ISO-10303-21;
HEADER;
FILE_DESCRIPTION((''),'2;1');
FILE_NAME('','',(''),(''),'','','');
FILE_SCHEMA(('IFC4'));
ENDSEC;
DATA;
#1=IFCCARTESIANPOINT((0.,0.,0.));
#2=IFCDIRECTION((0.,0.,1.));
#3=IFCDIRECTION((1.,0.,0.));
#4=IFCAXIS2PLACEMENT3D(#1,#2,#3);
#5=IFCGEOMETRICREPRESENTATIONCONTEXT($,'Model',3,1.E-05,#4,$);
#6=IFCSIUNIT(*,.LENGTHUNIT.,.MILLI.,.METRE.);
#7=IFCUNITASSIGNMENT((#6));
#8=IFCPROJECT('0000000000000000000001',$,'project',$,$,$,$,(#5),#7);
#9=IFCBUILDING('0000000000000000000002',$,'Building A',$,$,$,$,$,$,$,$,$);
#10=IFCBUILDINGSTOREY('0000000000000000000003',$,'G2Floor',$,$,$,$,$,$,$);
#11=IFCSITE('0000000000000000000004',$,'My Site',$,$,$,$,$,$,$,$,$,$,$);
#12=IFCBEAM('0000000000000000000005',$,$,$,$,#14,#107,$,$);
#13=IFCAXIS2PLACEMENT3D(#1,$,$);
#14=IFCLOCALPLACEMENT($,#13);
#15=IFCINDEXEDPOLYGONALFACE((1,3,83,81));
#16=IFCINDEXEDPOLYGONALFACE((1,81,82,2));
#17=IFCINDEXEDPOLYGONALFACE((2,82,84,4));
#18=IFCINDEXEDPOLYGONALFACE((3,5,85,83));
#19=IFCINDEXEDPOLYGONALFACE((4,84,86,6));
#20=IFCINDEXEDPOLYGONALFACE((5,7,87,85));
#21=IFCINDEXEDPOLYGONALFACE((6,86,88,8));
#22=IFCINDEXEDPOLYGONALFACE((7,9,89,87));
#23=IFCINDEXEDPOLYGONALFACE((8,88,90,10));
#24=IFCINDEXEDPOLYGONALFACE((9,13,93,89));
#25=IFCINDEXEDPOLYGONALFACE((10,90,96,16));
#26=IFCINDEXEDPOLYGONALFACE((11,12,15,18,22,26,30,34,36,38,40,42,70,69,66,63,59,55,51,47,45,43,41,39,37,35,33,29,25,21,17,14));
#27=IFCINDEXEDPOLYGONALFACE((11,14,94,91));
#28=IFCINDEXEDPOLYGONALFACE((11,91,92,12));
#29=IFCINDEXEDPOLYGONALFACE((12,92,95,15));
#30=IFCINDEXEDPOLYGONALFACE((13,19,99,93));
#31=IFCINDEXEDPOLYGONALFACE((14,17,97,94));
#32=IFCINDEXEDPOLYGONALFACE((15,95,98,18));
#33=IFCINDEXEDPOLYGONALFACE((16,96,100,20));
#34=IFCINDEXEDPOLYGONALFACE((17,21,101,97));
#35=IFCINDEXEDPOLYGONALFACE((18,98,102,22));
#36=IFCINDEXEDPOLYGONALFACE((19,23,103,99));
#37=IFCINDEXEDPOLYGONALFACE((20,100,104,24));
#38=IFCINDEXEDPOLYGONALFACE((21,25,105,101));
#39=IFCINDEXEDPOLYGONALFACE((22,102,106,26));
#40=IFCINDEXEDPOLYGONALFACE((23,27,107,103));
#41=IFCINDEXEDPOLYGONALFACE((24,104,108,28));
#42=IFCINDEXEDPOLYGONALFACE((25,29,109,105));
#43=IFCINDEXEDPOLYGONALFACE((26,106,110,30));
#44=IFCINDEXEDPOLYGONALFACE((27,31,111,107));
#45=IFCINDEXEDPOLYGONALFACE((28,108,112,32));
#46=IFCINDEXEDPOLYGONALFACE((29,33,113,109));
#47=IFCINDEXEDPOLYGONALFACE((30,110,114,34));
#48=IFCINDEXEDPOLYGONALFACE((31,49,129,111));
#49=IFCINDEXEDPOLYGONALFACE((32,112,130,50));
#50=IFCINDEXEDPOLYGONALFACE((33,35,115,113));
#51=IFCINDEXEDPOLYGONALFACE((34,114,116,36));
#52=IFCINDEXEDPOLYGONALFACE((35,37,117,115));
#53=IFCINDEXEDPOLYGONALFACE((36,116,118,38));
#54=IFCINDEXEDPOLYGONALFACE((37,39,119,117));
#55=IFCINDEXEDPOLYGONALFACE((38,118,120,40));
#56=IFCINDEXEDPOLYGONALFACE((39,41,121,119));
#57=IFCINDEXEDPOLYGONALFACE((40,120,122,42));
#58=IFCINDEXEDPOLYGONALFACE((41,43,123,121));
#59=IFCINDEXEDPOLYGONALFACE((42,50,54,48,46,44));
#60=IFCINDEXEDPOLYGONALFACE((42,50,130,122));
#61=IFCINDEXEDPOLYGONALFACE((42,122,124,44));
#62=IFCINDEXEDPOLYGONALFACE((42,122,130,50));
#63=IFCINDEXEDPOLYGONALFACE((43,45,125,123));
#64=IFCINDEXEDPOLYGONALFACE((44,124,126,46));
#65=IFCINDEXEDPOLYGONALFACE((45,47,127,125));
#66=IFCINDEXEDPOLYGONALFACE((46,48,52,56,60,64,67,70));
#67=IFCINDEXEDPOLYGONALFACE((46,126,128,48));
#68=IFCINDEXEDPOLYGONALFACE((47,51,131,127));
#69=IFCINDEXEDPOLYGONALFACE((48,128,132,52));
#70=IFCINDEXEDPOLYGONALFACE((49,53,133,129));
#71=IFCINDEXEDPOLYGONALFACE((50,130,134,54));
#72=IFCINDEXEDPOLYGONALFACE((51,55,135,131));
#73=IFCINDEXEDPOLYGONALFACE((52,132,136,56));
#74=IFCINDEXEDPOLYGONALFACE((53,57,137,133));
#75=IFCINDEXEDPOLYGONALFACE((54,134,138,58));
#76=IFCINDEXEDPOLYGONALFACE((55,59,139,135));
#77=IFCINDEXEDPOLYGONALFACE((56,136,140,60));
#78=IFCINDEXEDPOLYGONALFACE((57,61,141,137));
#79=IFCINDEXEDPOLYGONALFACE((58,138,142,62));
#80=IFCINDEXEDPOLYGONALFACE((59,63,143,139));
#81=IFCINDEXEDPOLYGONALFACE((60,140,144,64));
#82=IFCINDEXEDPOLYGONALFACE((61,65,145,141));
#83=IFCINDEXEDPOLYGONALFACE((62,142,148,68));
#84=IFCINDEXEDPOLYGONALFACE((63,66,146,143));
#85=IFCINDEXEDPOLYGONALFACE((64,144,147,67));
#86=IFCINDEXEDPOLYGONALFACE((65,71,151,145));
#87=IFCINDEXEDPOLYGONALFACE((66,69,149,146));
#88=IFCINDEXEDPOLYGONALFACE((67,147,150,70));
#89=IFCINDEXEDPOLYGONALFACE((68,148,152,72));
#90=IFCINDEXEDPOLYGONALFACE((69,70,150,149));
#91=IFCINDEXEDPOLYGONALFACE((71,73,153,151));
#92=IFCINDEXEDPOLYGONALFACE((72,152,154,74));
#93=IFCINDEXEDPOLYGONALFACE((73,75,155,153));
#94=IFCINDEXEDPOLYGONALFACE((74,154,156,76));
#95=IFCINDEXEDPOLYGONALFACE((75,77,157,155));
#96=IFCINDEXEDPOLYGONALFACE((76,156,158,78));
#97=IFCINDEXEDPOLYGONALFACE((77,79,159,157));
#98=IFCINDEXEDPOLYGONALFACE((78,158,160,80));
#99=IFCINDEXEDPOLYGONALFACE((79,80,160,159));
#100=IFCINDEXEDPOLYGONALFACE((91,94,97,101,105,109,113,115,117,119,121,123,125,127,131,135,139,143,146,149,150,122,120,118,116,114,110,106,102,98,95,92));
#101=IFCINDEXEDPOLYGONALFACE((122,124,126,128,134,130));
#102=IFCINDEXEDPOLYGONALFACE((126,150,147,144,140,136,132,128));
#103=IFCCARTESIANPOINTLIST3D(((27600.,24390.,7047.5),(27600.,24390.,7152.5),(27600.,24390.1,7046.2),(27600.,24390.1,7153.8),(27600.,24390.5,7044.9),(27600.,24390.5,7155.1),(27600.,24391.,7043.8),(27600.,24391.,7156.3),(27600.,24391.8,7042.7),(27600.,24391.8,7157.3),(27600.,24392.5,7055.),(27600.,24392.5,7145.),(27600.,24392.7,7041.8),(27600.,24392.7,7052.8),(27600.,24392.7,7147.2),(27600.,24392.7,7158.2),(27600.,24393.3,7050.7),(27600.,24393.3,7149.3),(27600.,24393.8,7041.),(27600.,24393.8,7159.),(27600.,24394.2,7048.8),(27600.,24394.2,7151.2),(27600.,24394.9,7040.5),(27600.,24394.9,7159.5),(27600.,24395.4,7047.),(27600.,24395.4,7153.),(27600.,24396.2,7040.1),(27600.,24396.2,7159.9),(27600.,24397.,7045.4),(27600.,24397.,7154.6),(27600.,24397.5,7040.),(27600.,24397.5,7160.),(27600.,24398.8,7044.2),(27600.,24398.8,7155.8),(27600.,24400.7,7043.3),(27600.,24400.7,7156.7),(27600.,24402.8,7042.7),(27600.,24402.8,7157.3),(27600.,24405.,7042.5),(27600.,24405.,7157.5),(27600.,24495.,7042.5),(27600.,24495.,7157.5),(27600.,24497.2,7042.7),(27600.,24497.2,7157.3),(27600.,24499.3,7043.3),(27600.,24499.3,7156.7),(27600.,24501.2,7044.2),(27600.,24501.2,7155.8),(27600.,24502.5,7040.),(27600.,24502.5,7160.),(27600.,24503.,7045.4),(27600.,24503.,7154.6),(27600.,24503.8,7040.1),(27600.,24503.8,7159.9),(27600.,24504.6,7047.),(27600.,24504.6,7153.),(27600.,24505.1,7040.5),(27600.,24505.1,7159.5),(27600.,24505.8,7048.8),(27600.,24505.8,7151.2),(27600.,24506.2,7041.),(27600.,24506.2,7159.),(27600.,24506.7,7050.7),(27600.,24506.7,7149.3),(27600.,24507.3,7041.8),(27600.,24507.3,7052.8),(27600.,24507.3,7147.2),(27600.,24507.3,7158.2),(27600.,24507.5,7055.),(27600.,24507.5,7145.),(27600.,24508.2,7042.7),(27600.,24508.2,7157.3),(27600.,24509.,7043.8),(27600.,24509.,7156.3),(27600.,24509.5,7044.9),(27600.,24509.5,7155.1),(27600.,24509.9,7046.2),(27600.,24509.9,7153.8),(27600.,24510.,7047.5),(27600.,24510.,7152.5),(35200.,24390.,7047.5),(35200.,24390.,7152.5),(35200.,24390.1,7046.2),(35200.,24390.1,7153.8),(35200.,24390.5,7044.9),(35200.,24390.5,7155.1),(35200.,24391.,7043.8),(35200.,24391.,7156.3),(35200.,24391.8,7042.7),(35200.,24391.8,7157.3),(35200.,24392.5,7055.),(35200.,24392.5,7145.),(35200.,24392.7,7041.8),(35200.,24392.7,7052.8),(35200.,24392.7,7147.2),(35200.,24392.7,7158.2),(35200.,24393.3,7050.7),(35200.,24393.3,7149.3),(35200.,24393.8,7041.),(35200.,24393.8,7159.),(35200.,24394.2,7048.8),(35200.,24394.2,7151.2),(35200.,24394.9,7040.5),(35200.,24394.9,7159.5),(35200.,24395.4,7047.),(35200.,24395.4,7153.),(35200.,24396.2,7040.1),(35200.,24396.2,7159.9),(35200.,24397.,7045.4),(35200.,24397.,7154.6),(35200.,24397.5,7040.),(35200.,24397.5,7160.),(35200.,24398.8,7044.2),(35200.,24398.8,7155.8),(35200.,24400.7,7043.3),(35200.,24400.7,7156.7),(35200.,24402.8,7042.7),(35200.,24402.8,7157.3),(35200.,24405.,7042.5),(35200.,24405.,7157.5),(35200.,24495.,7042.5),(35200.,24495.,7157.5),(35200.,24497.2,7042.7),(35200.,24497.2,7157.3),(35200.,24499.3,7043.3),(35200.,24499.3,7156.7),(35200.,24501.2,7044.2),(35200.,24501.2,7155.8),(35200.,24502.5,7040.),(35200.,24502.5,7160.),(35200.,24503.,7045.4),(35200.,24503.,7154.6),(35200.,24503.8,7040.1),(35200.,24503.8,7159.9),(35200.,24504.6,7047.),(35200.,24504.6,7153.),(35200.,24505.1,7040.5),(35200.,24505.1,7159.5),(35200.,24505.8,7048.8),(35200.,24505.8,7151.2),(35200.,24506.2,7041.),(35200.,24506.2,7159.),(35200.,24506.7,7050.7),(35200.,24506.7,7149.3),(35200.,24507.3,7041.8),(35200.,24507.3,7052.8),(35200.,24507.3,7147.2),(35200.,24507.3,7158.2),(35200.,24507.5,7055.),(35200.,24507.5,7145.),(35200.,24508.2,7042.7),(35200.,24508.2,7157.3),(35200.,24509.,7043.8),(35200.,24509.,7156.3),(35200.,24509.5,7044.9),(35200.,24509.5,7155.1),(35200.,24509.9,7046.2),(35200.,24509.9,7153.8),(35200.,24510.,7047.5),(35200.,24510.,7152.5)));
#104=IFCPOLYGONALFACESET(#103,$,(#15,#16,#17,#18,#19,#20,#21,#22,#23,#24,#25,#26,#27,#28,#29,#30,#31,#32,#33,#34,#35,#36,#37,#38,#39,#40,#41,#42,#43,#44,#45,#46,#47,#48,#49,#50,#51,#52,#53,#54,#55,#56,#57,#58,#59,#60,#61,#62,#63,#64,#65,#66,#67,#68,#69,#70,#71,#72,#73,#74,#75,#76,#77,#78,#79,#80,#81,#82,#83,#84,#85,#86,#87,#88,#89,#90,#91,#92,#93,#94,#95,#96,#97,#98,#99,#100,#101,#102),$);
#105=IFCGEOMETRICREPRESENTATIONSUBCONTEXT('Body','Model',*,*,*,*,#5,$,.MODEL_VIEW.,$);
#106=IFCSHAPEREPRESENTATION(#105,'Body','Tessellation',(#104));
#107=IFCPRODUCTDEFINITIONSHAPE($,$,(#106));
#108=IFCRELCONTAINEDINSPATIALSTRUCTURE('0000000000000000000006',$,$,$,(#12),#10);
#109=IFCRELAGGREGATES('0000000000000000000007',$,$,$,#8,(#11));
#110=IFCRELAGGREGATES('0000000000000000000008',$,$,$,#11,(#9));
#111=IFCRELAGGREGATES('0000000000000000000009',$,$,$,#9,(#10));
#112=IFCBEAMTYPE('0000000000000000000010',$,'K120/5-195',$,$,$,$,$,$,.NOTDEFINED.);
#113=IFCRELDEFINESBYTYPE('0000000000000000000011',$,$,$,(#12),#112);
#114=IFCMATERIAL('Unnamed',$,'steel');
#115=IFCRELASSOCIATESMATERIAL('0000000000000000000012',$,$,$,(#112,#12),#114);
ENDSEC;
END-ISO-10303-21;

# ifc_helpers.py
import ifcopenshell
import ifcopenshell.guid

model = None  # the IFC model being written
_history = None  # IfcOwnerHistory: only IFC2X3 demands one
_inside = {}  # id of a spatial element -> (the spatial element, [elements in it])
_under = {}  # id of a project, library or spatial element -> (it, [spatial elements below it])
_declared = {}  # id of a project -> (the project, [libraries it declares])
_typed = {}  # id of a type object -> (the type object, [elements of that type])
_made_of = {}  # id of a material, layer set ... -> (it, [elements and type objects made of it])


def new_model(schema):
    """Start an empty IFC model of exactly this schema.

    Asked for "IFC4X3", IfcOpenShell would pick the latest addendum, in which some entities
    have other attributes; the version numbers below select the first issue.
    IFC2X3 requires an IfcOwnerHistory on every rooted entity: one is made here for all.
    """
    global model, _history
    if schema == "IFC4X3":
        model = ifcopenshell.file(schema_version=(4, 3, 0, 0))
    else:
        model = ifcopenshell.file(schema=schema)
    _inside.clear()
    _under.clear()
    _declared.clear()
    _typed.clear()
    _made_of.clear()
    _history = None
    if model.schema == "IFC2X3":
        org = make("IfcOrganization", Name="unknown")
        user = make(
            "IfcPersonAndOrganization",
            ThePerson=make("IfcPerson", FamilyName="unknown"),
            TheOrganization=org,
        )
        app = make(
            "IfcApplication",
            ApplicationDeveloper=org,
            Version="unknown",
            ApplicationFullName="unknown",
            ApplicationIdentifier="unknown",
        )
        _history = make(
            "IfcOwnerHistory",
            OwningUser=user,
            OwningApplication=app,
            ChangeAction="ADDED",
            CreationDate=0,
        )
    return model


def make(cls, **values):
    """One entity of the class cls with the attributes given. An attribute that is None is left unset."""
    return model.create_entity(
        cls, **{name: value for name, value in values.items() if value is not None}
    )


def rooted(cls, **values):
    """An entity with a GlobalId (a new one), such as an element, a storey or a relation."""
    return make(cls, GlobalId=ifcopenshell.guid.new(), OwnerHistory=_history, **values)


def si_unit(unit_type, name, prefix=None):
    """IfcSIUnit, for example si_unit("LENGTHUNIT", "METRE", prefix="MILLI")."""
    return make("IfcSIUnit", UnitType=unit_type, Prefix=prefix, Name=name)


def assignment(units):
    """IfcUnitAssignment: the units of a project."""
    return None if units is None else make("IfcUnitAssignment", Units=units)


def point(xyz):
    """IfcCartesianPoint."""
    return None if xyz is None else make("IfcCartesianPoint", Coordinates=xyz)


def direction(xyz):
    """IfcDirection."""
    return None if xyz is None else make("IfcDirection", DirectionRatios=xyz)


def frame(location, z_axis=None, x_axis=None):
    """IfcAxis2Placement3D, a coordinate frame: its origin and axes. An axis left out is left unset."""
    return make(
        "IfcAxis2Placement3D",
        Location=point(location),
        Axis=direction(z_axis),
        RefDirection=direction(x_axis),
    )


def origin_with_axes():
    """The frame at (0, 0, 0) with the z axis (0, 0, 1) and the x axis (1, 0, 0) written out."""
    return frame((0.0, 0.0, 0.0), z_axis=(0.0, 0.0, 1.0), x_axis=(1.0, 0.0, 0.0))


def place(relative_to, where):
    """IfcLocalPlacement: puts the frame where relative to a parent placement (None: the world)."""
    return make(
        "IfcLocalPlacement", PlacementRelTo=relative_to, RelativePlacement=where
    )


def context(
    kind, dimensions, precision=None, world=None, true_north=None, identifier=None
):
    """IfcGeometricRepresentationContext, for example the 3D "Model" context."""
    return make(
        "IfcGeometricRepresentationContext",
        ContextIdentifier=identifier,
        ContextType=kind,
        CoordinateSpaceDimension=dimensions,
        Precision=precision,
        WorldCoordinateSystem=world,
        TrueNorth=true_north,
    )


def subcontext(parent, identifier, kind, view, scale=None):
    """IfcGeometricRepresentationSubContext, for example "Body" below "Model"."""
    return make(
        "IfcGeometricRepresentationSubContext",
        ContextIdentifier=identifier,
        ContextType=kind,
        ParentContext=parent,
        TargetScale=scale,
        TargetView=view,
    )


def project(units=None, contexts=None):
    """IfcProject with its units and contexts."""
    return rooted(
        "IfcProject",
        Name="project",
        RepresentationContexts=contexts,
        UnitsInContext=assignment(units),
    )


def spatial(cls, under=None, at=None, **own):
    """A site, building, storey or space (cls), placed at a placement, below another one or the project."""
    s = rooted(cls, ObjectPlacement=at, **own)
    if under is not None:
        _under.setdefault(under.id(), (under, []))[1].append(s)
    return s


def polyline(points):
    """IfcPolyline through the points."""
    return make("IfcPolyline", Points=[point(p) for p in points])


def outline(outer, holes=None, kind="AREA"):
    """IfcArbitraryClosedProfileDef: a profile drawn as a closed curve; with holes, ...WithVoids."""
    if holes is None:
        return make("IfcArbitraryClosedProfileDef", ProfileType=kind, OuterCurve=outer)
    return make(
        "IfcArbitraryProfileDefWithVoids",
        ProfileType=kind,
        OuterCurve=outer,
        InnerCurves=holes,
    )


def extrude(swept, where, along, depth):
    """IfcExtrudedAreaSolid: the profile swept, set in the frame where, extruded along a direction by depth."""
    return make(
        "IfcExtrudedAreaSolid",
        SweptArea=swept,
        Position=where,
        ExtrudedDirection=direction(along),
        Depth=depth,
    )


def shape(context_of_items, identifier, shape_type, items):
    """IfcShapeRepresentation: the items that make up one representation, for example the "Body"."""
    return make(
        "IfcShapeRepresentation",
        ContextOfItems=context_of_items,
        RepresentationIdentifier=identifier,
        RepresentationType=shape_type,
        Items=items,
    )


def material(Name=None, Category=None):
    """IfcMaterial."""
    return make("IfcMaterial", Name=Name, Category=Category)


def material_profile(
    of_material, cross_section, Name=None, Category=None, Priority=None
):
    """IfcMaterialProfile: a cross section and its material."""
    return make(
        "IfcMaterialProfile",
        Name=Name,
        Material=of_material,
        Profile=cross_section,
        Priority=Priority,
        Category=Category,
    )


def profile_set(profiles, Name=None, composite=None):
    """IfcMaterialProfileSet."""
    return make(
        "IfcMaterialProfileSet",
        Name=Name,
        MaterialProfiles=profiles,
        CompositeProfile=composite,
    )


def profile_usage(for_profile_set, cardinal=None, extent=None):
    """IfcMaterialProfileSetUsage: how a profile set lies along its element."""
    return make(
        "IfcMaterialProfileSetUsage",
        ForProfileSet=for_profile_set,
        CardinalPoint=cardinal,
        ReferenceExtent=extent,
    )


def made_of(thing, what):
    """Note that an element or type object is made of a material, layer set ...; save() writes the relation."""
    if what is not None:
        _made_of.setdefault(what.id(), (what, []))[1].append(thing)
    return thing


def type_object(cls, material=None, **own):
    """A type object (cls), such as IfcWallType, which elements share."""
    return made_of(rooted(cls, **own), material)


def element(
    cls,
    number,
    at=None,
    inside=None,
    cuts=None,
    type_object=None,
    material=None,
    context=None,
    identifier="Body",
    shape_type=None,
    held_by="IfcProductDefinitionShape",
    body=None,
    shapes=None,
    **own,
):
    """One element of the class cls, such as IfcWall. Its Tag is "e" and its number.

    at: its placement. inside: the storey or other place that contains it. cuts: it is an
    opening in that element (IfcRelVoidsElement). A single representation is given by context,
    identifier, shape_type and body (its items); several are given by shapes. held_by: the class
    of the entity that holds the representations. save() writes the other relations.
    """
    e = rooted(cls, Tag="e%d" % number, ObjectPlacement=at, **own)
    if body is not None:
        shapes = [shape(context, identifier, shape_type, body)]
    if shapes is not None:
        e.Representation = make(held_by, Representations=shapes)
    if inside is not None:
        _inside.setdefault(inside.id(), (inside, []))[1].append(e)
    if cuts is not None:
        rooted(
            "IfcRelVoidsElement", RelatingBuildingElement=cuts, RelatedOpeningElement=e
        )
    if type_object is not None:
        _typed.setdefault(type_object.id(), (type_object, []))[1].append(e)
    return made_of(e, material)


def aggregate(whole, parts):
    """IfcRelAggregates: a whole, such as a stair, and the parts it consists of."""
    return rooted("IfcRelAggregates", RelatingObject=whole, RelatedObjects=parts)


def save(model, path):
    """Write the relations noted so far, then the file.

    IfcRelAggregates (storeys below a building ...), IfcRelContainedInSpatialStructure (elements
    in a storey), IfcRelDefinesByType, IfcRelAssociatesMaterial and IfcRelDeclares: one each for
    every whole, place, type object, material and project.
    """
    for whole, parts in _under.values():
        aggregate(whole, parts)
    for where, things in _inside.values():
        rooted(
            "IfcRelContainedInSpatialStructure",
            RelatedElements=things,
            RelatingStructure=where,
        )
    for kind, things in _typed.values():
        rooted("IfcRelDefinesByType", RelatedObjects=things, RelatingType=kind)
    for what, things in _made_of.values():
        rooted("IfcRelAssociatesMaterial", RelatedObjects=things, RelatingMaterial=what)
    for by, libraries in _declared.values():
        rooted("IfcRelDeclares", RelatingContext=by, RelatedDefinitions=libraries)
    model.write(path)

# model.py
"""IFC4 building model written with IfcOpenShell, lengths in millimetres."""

from ifc_helpers import new_model, si_unit, frame, origin_with_axes, place, context, subcontext, project, spatial, polyline, outline, extrude, material, material_profile, profile_set, profile_usage, type_object, element, save


model = new_model("IFC4")

# Units and contexts
model_context = context("Model", 3, precision=1e-05, world=origin_with_axes())
body_context = subcontext(model_context, "Body", "Model", "MODEL_VIEW")
ifc_project = project(units=[si_unit("LENGTHUNIT", "METRE", prefix="MILLI")], contexts=[model_context])

# Site, building, storey
site = spatial("IfcSite", under=ifc_project, Name="My Site")
building = spatial("IfcBuilding", under=site, Name="Building A")
storey = spatial("IfcBuildingStorey", under=building, Name="G2Floor")

# Beam
ifc_material_1 = material(Name="Unnamed", Category="steel")
ifc_material_profile_1 = material_profile(ifc_material_1, outline(polyline([(-52.5, -60.0), (52.5, -60.0), (52.5, -60.0), (53.8, -59.9), (53.8, -59.9), (55.1, -59.5), (55.1, -59.5), (56.2, -59.0), (56.2, -59.0), (57.3, -58.2), (57.3, -58.2), (58.2, -57.3), (58.2, -57.3), (59.0, -56.2), (59.0, -56.2), (59.5, -55.1), (59.5, -55.1), (59.9, -53.8), (59.9, -53.8), (60.0, -52.5), (60.0, -52.5), (60.0, 52.5), (60.0, 52.5), (59.9, 53.8), (59.9, 53.8), (59.5, 55.1), (59.5, 55.1), (59.0, 56.2), (59.0, 56.2), (58.2, 57.3), (58.2, 57.3), (57.3, 58.2), (57.3, 58.2), (56.2, 59.0), (56.2, 59.0), (55.1, 59.5), (55.1, 59.5), (53.8, 59.9), (53.8, 59.9), (52.5, 60.0), (52.5, 60.0), (-52.5, 60.0), (-52.5, 60.0), (-53.8, 59.9), (-53.8, 59.9), (-55.1, 59.5), (-55.1, 59.5), (-56.2, 59.0), (-56.2, 59.0), (-57.3, 58.2), (-57.3, 58.2), (-58.2, 57.3), (-58.2, 57.3), (-59.0, 56.2), (-59.0, 56.2), (-59.5, 55.1), (-59.5, 55.1), (-59.9, 53.8), (-59.9, 53.8), (-60.0, 52.5), (-60.0, 52.5), (-60.0, -52.5), (-60.0, -52.5), (-59.9, -53.8), (-59.9, -53.8), (-59.5, -55.1), (-59.5, -55.1), (-59.0, -56.2), (-59.0, -56.2), (-58.2, -57.3), (-58.2, -57.3), (-57.3, -58.2), (-57.3, -58.2), (-56.2, -59.0), (-56.2, -59.0), (-55.1, -59.5), (-55.1, -59.5), (-53.8, -59.9), (-53.8, -59.9), (-52.5, -60.0), (-52.5, -60.0), (-45.0, -57.5), (-45.0, -57.5), (45.0, -57.5), (45.0, -57.5), (47.2, -57.3), (47.2, -57.3), (49.3, -56.7), (49.3, -56.7), (51.2, -55.8), (51.2, -55.8), (53.0, -54.6), (53.0, -54.6), (54.6, -53.0), (54.6, -53.0), (55.8, -51.2), (55.8, -51.2), (56.7, -49.3), (56.7, -49.3), (57.3, -47.2), (57.3, -47.2), (57.5, -45.0), (57.5, -45.0), (57.5, 45.0), (57.5, 45.0), (57.3, 47.2), (57.3, 47.2), (56.7, 49.3), (56.7, 49.3), (55.8, 51.2), (55.8, 51.2), (54.6, 53.0), (54.6, 53.0), (53.0, 54.6), (53.0, 54.6), (51.2, 55.8), (51.2, 55.8), (49.3, 56.7), (49.3, 56.7), (47.2, 57.3), (47.2, 57.3), (45.0, 57.5), (45.0, 57.5), (-45.0, 57.5), (-45.0, 57.5), (-47.2, 57.3), (-47.2, 57.3), (-49.3, 56.7), (-49.3, 56.7), (-51.2, 55.8), (-51.2, 55.8), (-53.0, 54.6), (-53.0, 54.6), (-54.6, 53.0), (-54.6, 53.0), (-55.8, 51.2), (-55.8, 51.2), (-56.7, 49.3), (-56.7, 49.3), (-57.3, 47.2), (-57.3, 47.2), (-57.5, 45.0), (-57.5, 45.0), (-57.5, -45.0), (-57.5, -45.0), (-57.3, -47.2), (-57.3, -47.2), (-56.7, -49.3), (-56.7, -49.3), (-55.8, -51.2), (-55.8, -51.2), (-54.6, -53.0), (-54.6, -53.0), (-53.0, -54.6), (-53.0, -54.6), (-51.2, -55.8), (-51.2, -55.8), (-49.3, -56.7), (-49.3, -56.7), (-47.2, -57.3), (-47.2, -57.3), (-45.0, -57.5), (-45.0, -57.5), (-52.5, -60.0)])))
ifc_profile_set_1 = profile_set([ifc_material_profile_1], Name="K120/5-195")
ifc_profile_usage_1 = profile_usage(ifc_profile_set_1)
beam_type_1 = type_object("IfcBeamType", Name="K120/5-195", PredefinedType="NOTDEFINED", material=ifc_profile_set_1)
beam_1_placement = place(None, frame((27600.0, 24450.0, 7100.0), z_axis=(1.0, 0.0, 0.0), x_axis=(0.0, -1.0, 0.0)))
element("IfcBeam", 1, at=beam_1_placement, inside=storey, type_object=beam_type_1, material=ifc_profile_usage_1, context=body_context, shape_type="SweptSolid", body=[
    extrude(outline(polyline([(-52.5, -60.0), (52.5, -60.0), (52.5, -60.0), (53.8, -59.9), (53.8, -59.9), (55.1, -59.5), (55.1, -59.5), (56.2, -59.0), (56.2, -59.0), (57.3, -58.2), (57.3, -58.2), (58.2, -57.3), (58.2, -57.3), (59.0, -56.2), (59.0, -56.2), (59.5, -55.1), (59.5, -55.1), (59.9, -53.8), (59.9, -53.8), (60.0, -52.5), (60.0, -52.5), (60.0, 52.5), (60.0, 52.5), (59.9, 53.8), (59.9, 53.8), (59.5, 55.1), (59.5, 55.1), (59.0, 56.2), (59.0, 56.2), (58.2, 57.3), (58.2, 57.3), (57.3, 58.2), (57.3, 58.2), (56.2, 59.0), (56.2, 59.0), (55.1, 59.5), (55.1, 59.5), (53.8, 59.9), (53.8, 59.9), (52.5, 60.0), (52.5, 60.0), (-52.5, 60.0), (-52.5, 60.0), (-53.8, 59.9), (-53.8, 59.9), (-55.1, 59.5), (-55.1, 59.5), (-56.2, 59.0), (-56.2, 59.0), (-57.3, 58.2), (-57.3, 58.2), (-58.2, 57.3), (-58.2, 57.3), (-59.0, 56.2), (-59.0, 56.2), (-59.5, 55.1), (-59.5, 55.1), (-59.9, 53.8), (-59.9, 53.8), (-60.0, 52.5), (-60.0, 52.5), (-60.0, -52.5), (-60.0, -52.5), (-59.9, -53.8), (-59.9, -53.8), (-59.5, -55.1), (-59.5, -55.1), (-59.0, -56.2), (-59.0, -56.2), (-58.2, -57.3), (-58.2, -57.3), (-57.3, -58.2), (-57.3, -58.2), (-56.2, -59.0), (-56.2, -59.0), (-55.1, -59.5), (-55.1, -59.5), (-53.8, -59.9), (-53.8, -59.9), (-52.5, -60.0), (-52.5, -60.0), (-45.0, -57.5), (-45.0, -57.5), (45.0, -57.5), (45.0, -57.5), (47.2, -57.3), (47.2, -57.3), (49.3, -56.7), (49.3, -56.7), (51.2, -55.8), (51.2, -55.8), (53.0, -54.6), (53.0, -54.6), (54.6, -53.0), (54.6, -53.0), (55.8, -51.2), (55.8, -51.2), (56.7, -49.3), (56.7, -49.3), (57.3, -47.2), (57.3, -47.2), (57.5, -45.0), (57.5, -45.0), (57.5, 45.0), (57.5, 45.0), (57.3, 47.2), (57.3, 47.2), (56.7, 49.3), (56.7, 49.3), (55.8, 51.2), (55.8, 51.2), (54.6, 53.0), (54.6, 53.0), (53.0, 54.6), (53.0, 54.6), (51.2, 55.8), (51.2, 55.8), (49.3, 56.7), (49.3, 56.7), (47.2, 57.3), (47.2, 57.3), (45.0, 57.5), (45.0, 57.5), (-45.0, 57.5), (-45.0, 57.5), (-47.2, 57.3), (-47.2, 57.3), (-49.3, 56.7), (-49.3, 56.7), (-51.2, 55.8), (-51.2, 55.8), (-53.0, 54.6), (-53.0, 54.6), (-54.6, 53.0), (-54.6, 53.0), (-55.8, 51.2), (-55.8, 51.2), (-56.7, 49.3), (-56.7, 49.3), (-57.3, 47.2), (-57.3, 47.2), (-57.5, 45.0), (-57.5, 45.0), (-57.5, -45.0), (-57.5, -45.0), (-57.3, -47.2), (-57.3, -47.2), (-56.7, -49.3), (-56.7, -49.3), (-55.8, -51.2), (-55.8, -51.2), (-54.6, -53.0), (-54.6, -53.0), (-53.0, -54.6), (-53.0, -54.6), (-51.2, -55.8), (-51.2, -55.8), (-49.3, -56.7), (-49.3, -56.7), (-47.2, -57.3), (-47.2, -57.3), (-45.0, -57.5), (-45.0, -57.5), (-52.5, -60.0)])), origin_with_axes(), (0.0, 0.0, 1.0), 7600.0),
])

save(model, "model.ifc")
